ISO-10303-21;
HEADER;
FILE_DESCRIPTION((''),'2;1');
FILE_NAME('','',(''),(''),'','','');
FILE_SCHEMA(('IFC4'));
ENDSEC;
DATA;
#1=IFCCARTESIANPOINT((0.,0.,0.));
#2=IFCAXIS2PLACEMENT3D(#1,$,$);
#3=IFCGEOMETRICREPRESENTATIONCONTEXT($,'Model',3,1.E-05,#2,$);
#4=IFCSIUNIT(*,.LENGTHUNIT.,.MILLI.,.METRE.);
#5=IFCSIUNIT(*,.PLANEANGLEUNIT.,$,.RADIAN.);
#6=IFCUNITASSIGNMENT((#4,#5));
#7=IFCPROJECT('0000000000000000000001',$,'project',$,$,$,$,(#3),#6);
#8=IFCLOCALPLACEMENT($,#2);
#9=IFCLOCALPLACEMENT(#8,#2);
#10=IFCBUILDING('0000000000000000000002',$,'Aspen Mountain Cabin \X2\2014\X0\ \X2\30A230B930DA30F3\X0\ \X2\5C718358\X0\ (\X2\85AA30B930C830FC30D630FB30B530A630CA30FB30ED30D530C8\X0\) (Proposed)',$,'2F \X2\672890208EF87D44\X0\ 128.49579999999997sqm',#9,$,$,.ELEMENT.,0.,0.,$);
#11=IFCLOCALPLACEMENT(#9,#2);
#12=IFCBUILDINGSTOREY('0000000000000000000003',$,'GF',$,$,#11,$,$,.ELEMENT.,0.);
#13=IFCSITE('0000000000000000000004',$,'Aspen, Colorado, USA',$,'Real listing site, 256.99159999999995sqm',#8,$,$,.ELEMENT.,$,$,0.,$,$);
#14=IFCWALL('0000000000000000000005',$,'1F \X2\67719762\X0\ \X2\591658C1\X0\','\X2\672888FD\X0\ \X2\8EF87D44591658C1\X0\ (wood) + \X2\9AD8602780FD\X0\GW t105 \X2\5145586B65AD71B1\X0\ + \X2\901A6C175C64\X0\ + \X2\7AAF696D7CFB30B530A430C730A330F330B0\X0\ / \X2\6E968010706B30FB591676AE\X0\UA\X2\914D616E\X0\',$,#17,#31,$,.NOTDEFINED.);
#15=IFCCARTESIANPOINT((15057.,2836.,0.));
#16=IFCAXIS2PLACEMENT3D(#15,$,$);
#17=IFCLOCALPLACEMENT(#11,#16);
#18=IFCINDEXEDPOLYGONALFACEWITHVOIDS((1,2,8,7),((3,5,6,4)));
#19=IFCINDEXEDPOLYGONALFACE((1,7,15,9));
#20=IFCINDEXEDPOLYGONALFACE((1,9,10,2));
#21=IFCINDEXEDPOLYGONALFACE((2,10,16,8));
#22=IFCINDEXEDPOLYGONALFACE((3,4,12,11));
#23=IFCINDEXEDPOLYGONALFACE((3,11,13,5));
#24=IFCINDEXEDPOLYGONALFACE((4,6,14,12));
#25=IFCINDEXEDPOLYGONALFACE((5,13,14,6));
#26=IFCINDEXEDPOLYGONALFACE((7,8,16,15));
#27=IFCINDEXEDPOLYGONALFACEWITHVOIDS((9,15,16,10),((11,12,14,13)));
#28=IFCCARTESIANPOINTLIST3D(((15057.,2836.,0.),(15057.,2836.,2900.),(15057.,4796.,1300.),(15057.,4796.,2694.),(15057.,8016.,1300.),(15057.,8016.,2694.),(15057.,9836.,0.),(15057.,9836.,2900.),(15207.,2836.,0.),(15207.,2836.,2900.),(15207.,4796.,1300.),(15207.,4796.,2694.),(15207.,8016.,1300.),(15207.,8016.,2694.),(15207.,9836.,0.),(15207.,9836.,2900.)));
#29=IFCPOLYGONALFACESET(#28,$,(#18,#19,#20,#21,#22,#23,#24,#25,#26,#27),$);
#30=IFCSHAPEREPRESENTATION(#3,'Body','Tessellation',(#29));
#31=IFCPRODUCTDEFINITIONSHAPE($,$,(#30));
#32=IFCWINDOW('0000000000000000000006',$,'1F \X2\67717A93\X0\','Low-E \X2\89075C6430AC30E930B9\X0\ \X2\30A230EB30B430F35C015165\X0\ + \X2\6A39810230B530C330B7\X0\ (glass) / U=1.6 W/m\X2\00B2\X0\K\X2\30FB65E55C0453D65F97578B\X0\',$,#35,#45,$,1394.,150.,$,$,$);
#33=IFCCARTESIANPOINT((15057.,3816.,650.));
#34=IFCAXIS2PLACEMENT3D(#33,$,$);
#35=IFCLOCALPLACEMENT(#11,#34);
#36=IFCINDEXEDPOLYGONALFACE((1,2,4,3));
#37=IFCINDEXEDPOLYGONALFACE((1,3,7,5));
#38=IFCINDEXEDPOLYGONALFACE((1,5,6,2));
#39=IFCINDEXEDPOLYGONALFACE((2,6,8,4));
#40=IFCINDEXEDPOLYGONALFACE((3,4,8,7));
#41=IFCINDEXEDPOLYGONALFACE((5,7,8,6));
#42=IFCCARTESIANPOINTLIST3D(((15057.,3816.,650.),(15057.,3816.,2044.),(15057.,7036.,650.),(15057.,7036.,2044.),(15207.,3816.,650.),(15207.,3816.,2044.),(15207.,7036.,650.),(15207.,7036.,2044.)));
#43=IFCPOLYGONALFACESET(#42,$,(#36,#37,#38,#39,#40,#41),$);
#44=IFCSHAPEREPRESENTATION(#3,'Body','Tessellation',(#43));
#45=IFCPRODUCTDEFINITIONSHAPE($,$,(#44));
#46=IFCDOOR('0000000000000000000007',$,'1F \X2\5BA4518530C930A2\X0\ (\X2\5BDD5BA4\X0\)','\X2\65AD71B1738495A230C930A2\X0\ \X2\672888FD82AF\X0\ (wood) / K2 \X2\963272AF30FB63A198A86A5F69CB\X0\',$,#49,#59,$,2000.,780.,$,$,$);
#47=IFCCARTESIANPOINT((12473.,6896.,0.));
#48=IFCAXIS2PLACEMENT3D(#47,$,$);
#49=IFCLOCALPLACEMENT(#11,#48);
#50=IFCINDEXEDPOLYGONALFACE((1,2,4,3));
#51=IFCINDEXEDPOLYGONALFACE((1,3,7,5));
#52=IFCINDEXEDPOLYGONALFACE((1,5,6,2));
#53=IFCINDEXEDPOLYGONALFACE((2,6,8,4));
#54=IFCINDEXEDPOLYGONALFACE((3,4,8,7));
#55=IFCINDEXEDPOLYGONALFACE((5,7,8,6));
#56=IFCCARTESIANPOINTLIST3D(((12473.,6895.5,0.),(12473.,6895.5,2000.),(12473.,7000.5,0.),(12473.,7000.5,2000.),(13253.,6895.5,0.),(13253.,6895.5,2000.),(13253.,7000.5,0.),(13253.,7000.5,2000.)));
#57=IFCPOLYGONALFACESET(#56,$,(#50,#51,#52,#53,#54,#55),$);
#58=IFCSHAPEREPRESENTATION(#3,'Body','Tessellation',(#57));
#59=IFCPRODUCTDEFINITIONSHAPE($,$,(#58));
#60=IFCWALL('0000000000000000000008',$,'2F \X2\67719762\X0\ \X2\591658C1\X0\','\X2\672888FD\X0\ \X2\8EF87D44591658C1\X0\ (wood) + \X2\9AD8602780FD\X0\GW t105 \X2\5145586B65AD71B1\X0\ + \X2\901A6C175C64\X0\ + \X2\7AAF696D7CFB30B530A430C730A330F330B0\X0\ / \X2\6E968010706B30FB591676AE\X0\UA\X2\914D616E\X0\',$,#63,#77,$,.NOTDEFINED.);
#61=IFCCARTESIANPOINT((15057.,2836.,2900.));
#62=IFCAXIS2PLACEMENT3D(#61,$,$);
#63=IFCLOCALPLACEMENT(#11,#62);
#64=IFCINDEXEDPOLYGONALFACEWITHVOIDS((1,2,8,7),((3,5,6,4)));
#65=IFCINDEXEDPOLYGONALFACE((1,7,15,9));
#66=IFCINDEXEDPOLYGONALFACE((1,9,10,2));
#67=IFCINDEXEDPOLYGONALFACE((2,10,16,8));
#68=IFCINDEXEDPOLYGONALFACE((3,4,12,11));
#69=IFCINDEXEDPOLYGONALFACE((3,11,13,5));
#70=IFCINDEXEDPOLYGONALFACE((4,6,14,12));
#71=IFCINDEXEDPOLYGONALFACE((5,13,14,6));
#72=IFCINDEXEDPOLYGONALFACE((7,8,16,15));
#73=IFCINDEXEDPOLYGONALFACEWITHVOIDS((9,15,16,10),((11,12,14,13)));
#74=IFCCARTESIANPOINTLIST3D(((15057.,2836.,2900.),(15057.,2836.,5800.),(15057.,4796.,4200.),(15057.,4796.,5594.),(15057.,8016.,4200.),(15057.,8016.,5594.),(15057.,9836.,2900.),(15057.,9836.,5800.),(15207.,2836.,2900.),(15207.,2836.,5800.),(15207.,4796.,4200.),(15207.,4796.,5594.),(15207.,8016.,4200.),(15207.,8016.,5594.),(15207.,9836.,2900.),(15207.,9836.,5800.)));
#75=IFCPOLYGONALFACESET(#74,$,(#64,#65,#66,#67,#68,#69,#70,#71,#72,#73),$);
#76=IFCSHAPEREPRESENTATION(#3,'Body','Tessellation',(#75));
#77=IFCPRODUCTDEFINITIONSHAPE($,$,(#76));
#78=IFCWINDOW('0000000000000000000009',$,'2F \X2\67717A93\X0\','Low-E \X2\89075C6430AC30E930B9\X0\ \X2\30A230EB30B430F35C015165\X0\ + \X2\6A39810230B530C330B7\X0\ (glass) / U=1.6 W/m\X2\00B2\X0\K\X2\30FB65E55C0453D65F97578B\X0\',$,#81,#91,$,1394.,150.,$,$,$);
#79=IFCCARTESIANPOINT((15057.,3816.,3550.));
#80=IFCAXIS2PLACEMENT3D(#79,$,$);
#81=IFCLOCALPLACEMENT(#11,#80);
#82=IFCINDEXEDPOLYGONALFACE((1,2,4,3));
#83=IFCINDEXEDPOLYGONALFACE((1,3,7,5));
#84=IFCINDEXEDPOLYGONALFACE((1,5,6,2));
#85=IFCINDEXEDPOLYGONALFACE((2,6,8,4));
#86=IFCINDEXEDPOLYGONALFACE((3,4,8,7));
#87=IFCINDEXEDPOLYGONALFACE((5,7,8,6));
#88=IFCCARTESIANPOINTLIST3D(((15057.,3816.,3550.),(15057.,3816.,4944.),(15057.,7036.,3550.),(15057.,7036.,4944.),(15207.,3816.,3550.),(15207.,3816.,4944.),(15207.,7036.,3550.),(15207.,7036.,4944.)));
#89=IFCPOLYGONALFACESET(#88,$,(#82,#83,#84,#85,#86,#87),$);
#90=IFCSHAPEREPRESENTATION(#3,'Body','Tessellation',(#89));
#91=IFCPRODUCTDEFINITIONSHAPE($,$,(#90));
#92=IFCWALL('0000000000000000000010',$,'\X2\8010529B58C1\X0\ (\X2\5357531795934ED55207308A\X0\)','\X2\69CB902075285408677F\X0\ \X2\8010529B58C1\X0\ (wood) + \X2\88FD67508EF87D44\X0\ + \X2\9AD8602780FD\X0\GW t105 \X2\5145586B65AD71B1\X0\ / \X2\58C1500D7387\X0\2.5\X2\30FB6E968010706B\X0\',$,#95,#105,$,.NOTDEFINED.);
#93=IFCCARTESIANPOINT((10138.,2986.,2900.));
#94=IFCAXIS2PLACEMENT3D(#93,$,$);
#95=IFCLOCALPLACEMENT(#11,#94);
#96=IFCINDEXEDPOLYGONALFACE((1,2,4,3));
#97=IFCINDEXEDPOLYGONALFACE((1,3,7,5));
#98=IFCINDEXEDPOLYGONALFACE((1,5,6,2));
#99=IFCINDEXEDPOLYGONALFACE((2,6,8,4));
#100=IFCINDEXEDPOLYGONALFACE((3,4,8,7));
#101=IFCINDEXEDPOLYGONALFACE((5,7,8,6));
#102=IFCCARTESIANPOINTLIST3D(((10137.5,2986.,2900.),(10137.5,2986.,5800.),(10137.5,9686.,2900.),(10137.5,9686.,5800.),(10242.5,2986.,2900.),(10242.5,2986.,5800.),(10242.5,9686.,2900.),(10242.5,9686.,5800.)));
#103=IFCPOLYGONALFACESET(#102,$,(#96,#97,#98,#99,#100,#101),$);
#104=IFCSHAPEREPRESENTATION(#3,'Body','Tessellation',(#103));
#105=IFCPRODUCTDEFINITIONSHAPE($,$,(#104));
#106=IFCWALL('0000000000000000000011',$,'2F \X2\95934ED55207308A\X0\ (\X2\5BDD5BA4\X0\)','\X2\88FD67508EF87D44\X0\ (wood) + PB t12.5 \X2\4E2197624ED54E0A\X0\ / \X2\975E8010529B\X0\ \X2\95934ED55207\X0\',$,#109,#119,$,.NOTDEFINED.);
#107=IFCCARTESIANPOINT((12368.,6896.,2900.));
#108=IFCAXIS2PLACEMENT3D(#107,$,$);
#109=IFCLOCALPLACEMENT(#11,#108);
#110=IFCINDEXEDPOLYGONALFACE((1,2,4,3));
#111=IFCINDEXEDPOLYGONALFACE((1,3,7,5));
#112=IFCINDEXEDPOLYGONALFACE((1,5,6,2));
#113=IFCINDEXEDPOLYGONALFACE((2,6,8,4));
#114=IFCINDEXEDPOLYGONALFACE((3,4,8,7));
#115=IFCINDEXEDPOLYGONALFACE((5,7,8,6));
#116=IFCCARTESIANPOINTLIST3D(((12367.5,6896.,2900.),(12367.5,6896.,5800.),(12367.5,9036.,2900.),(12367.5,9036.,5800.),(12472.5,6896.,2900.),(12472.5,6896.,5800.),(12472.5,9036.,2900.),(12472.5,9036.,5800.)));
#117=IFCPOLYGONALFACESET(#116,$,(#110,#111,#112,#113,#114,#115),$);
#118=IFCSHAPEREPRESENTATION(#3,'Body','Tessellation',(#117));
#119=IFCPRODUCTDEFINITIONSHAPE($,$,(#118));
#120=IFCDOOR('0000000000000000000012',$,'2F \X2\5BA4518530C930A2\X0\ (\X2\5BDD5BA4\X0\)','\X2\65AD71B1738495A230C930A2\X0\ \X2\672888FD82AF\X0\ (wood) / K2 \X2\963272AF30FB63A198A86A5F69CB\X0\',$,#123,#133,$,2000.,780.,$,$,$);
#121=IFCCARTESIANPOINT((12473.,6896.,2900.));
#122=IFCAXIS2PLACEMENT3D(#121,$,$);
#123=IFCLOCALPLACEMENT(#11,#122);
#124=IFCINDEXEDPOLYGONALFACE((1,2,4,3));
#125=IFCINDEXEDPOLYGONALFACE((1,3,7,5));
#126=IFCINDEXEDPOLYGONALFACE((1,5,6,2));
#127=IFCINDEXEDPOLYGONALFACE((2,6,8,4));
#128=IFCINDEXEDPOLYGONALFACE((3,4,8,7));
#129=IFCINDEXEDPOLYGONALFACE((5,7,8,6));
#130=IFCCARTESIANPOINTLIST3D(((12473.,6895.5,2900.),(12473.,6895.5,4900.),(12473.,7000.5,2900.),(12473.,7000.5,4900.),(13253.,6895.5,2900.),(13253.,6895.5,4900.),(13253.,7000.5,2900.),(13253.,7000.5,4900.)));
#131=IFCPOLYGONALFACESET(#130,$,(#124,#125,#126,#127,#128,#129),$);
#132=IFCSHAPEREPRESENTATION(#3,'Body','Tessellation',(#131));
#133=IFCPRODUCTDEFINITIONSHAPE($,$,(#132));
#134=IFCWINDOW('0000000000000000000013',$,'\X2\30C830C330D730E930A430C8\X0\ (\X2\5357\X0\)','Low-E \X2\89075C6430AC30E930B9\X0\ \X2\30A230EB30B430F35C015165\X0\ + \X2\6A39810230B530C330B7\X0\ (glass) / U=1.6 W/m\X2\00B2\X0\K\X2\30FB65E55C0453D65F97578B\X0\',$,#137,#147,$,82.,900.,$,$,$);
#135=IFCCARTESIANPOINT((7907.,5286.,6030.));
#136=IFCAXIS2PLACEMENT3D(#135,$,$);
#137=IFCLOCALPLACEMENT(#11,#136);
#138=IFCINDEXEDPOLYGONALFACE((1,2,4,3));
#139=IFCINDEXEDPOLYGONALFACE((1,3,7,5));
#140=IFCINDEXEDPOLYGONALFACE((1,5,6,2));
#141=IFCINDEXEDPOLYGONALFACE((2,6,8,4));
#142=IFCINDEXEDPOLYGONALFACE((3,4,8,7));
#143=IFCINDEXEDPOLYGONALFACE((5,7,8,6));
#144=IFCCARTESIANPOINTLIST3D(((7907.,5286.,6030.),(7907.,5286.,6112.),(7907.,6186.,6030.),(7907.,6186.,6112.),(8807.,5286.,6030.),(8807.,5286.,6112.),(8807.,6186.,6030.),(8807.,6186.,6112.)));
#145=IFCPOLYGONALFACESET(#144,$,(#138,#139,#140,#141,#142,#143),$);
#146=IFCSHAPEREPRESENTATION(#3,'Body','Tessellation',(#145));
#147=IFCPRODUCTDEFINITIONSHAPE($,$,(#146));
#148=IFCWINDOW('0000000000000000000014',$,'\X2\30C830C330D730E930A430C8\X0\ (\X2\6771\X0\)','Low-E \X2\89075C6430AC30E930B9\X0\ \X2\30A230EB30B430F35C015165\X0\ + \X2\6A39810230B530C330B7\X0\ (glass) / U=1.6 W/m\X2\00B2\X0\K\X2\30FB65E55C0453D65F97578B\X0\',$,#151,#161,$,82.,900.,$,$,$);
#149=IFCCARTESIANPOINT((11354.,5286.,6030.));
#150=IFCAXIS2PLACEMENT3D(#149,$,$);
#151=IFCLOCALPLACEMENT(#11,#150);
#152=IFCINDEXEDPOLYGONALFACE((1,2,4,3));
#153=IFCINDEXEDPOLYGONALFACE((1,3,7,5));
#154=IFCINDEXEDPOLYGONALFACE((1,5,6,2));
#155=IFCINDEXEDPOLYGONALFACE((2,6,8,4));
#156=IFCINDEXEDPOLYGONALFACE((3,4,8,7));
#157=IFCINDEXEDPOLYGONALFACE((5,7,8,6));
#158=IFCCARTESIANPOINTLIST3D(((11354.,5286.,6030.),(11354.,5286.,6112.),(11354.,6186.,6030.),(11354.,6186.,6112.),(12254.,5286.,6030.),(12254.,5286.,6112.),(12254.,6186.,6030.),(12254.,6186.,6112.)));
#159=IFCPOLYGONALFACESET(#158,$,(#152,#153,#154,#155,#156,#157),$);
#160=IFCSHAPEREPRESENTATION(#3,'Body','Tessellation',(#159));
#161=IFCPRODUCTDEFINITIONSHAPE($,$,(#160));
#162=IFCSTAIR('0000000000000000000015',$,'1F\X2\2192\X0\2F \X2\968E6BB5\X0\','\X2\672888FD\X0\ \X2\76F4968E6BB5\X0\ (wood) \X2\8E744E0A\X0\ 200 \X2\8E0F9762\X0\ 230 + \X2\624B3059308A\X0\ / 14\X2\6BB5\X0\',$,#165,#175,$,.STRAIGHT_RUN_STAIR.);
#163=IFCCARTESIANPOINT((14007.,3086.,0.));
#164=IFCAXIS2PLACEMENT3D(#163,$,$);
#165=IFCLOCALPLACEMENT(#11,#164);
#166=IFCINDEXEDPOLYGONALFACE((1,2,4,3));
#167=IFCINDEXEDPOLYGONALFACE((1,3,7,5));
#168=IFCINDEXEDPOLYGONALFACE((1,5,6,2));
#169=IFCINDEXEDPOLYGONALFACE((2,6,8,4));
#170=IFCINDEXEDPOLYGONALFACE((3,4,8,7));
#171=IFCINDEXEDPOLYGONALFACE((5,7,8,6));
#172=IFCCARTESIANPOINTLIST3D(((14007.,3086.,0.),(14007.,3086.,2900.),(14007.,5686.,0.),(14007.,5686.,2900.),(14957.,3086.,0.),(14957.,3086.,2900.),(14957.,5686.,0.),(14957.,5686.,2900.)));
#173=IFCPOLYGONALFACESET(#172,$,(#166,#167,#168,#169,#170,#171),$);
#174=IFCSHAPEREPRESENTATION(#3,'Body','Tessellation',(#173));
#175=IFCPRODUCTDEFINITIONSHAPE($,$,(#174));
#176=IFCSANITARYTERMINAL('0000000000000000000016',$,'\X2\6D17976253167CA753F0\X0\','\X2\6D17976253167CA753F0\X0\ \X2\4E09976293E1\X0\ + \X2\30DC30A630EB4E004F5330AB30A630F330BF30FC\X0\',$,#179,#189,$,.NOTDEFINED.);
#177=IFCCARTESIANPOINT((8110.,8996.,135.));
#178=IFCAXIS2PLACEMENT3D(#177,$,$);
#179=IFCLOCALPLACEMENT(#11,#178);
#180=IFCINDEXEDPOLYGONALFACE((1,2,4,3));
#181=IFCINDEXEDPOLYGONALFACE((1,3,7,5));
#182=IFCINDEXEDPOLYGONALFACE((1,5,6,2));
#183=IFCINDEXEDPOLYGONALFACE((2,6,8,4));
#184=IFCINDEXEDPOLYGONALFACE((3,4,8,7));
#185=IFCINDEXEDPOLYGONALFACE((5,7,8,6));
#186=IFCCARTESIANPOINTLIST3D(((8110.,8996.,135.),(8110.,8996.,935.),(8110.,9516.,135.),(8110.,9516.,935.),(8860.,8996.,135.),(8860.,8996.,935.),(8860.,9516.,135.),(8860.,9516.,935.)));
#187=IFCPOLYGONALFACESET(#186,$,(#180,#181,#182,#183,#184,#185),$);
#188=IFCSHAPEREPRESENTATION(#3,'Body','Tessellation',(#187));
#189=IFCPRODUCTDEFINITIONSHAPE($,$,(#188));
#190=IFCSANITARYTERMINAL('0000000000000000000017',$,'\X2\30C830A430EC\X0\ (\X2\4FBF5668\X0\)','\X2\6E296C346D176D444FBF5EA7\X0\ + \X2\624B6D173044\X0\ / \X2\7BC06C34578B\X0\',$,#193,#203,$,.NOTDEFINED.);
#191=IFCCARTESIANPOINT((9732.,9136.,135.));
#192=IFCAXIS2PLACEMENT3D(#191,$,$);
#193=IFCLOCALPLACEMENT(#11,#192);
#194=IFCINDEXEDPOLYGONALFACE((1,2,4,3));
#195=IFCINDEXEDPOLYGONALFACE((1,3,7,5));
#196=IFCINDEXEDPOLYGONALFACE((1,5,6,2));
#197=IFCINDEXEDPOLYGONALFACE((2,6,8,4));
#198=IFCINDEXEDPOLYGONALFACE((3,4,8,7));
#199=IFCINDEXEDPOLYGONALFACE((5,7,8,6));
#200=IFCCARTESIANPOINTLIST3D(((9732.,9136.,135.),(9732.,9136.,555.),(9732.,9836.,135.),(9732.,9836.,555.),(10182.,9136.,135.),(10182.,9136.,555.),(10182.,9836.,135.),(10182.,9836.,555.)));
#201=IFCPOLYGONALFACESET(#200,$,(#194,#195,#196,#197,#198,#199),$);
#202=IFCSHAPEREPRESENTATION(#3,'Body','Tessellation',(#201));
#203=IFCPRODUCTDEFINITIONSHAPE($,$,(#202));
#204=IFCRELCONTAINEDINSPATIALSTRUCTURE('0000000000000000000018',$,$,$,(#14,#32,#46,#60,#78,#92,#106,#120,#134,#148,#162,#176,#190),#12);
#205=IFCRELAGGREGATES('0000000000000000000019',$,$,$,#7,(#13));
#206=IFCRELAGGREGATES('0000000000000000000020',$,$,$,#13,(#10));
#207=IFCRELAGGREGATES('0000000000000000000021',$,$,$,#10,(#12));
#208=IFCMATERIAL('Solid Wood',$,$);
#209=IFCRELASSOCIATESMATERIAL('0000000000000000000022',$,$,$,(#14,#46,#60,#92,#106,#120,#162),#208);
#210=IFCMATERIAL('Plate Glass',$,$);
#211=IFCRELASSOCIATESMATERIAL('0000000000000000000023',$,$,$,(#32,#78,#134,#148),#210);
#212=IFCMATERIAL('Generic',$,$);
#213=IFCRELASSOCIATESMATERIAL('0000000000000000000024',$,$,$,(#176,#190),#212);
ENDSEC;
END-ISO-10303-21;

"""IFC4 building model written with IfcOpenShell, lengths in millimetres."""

from ifc_helpers import new_model, si_unit, frame, frame_2d, origin, place, context, project, spatial, rectangle, extrude, material, element, fill, save


model = new_model("IFC4")

# Units and contexts
model_context = context("Model", 3, precision=1e-05, world=origin())
ifc_project = project(units=[si_unit("LENGTHUNIT", "METRE", prefix="MILLI"), si_unit("PLANEANGLEUNIT", "RADIAN")], contexts=[model_context])

# Site, building, storey
site_placement = place(None, origin())
site = spatial("IfcSite", under=ifc_project, at=site_placement, Name="Aspen, Colorado, USA", ObjectType="Real listing site, 256.99159999999995sqm", CompositionType="ELEMENT", RefElevation=0.0)
building_placement = place(site_placement, origin())
building = spatial("IfcBuilding", under=site, at=building_placement, Name="Aspen Mountain Cabin — アスペン 山荘 (薪ストーブ・サウナ・ロフト) (Proposed)", ObjectType="2F 木造軸組 128.49579999999997sqm", CompositionType="ELEMENT", ElevationOfRefHeight=0.0, ElevationOfTerrain=0.0)
storey_placement = place(building_placement, origin())
storey = spatial("IfcBuildingStorey", under=building, at=storey_placement, Name="GF", CompositionType="ELEMENT", Elevation=0.0)

# Wall, opening, window
ifc_material_1 = material(Name="Solid Wood")
wall_1_placement = place(storey_placement, frame((15057.0, 2836.0, 0.0)))
wall_1 = element("IfcWall", 1, at=wall_1_placement, inside=storey, material=ifc_material_1, Name="1F 東面 外壁", Description="木製 軸組外壁 (wood) + 高性能GW t105 充填断熱 + 通気層 + 窯業系サイディング / 準耐火・外皮UA配慮", PredefinedType="NOTDEFINED", context=model_context, shape_type="SweptSolid", body=[
    extrude(rectangle(XDim=150.0, YDim=7000.0, at=frame_2d((75.0, 3500.0))), frame((15057.0, 2836.0, 0.0)), (0.0, 0.0, 1.0), 2900.0),
])
opening_1_placement = place(storey_placement, frame((15057.0, 3816.0, 650.0)))
opening_1 = element("IfcOpeningElement", 2, at=opening_1_placement, cuts=wall_1, PredefinedType="NOTDEFINED", context=model_context, shape_type="SweptSolid", body=[
    extrude(rectangle(XDim=150.0, YDim=3220.0, at=frame_2d((75.0, 1610.0))), frame((15057.0, 3816.0, 650.0)), (0.0, 0.0, 1.0), 1394.0),
])
ifc_material_2 = material(Name="Plate Glass")
window_1_placement = place(storey_placement, frame((15057.0, 3816.0, 650.0)))
window_1 = element("IfcWindow", 3, at=window_1_placement, inside=storey, material=ifc_material_2, Name="1F 東窓", Description="Low-E 複層ガラス アルゴン封入 + 樹脂サッシ (glass) / U=1.6 W/m²K・日射取得型", OverallHeight=1394.0, OverallWidth=150.0, context=model_context, shape_type="SweptSolid", body=[
    extrude(rectangle(XDim=150.0, YDim=3220.0, at=frame_2d((75.0, 1610.0))), frame((15057.0, 3816.0, 650.0)), (0.0, 0.0, 1.0), 1394.0),
])
fill(opening_1, window_1)

# Door
door_1_placement = place(storey_placement, frame((12473.0, 6896.0, 0.0)))
element("IfcDoor", 4, at=door_1_placement, inside=storey, material=ifc_material_1, Name="1F 室内ドア (寝室)", Description="断熱玄関ドア 木製芯 (wood) / K2 防犯・採風機構", OverallHeight=2000.0, OverallWidth=780.0, context=model_context, shape_type="SweptSolid", body=[
    extrude(rectangle(XDim=780.0, YDim=105.0, at=frame_2d((390.0, 52.0))), frame((12473.0, 6896.0, 0.0)), (0.0, 0.0, 1.0), 2000.0),
])

# Wall, opening, window
wall_2_placement = place(storey_placement, frame((15057.0, 2836.0, 2900.0)))
wall_2 = element("IfcWall", 5, at=wall_2_placement, inside=storey, material=ifc_material_1, Name="2F 東面 外壁", Description="木製 軸組外壁 (wood) + 高性能GW t105 充填断熱 + 通気層 + 窯業系サイディング / 準耐火・外皮UA配慮", PredefinedType="NOTDEFINED", context=model_context, shape_type="SweptSolid", body=[
    extrude(rectangle(XDim=150.0, YDim=7000.0, at=frame_2d((75.0, 3500.0))), frame((15057.0, 2836.0, 2900.0)), (0.0, 0.0, 1.0), 2900.0),
])
opening_2_placement = place(storey_placement, frame((15057.0, 3816.0, 3550.0)))
opening_2 = element("IfcOpeningElement", 6, at=opening_2_placement, cuts=wall_2, PredefinedType="NOTDEFINED", context=model_context, shape_type="SweptSolid", body=[
    extrude(rectangle(XDim=150.0, YDim=3220.0, at=frame_2d((75.0, 1610.0))), frame((15057.0, 3816.0, 3550.0)), (0.0, 0.0, 1.0), 1394.0),
])
window_2_placement = place(storey_placement, frame((15057.0, 3816.0, 3550.0)))
window_2 = element("IfcWindow", 7, at=window_2_placement, inside=storey, material=ifc_material_2, Name="2F 東窓", Description="Low-E 複層ガラス アルゴン封入 + 樹脂サッシ (glass) / U=1.6 W/m²K・日射取得型", OverallHeight=1394.0, OverallWidth=150.0, context=model_context, shape_type="SweptSolid", body=[
    extrude(rectangle(XDim=150.0, YDim=3220.0, at=frame_2d((75.0, 1610.0))), frame((15057.0, 3816.0, 3550.0)), (0.0, 0.0, 1.0), 1394.0),
])
fill(opening_2, window_2)

# Walls
wall_3_placement = place(storey_placement, frame((10138.0, 2986.0, 2900.0)))
element("IfcWall", 8, at=wall_3_placement, inside=storey, material=ifc_material_1, Name="耐力壁 (南北間仕切り)", Description="構造用合板 耐力壁 (wood) + 製材軸組 + 高性能GW t105 充填断熱 / 壁倍率2.5・準耐火", PredefinedType="NOTDEFINED", context=model_context, shape_type="SweptSolid", body=[
    extrude(rectangle(XDim=105.0, YDim=6700.0, at=frame_2d((52.0, 3350.0))), frame((10138.0, 2986.0, 2900.0)), (0.0, 0.0, 1.0), 2900.0),
])
wall_4_placement = place(storey_placement, frame((12368.0, 6896.0, 2900.0)))
element("IfcWall", 9, at=wall_4_placement, inside=storey, material=ifc_material_1, Name="2F 間仕切り (寝室)", Description="製材軸組 (wood) + PB t12.5 両面仕上 / 非耐力 間仕切", PredefinedType="NOTDEFINED", context=model_context, shape_type="SweptSolid", body=[
    extrude(rectangle(XDim=105.0, YDim=2140.0, at=frame_2d((52.0, 1070.0))), frame((12368.0, 6896.0, 2900.0)), (0.0, 0.0, 1.0), 2900.0),
])

# Door
door_2_placement = place(storey_placement, frame((12473.0, 6896.0, 2900.0)))
element("IfcDoor", 10, at=door_2_placement, inside=storey, material=ifc_material_1, Name="2F 室内ドア (寝室)", Description="断熱玄関ドア 木製芯 (wood) / K2 防犯・採風機構", OverallHeight=2000.0, OverallWidth=780.0, context=model_context, shape_type="SweptSolid", body=[
    extrude(rectangle(XDim=780.0, YDim=105.0, at=frame_2d((390.0, 52.0))), frame((12473.0, 6896.0, 2900.0)), (0.0, 0.0, 1.0), 2000.0),
])

# Windows
window_3_placement = place(storey_placement, frame((7907.0, 5286.0, 6030.0)))
element("IfcWindow", 11, at=window_3_placement, inside=storey, material=ifc_material_2, Name="トップライト (南)", Description="Low-E 複層ガラス アルゴン封入 + 樹脂サッシ (glass) / U=1.6 W/m²K・日射取得型", OverallHeight=82.0, OverallWidth=900.0, context=model_context, shape_type="SweptSolid", body=[
    extrude(rectangle(XDim=900.0, YDim=900.0, at=frame_2d((450.0, 450.0))), frame((7907.0, 5286.0, 6030.0)), (0.0, 0.0, 1.0), 82.0),
])
window_4_placement = place(storey_placement, frame((11354.0, 5286.0, 6030.0)))
element("IfcWindow", 12, at=window_4_placement, inside=storey, material=ifc_material_2, Name="トップライト (東)", Description="Low-E 複層ガラス アルゴン封入 + 樹脂サッシ (glass) / U=1.6 W/m²K・日射取得型", OverallHeight=82.0, OverallWidth=900.0, context=model_context, shape_type="SweptSolid", body=[
    extrude(rectangle(XDim=900.0, YDim=900.0, at=frame_2d((450.0, 450.0))), frame((11354.0, 5286.0, 6030.0)), (0.0, 0.0, 1.0), 82.0),
])

# Stair
stair_placement = place(storey_placement, frame((14007.0, 3086.0, 0.0)))
element("IfcStair", 13, at=stair_placement, inside=storey, material=ifc_material_1, Name="1F→2F 階段", Description="木製 直階段 (wood) 蹴上 200 踏面 230 + 手すり / 14段", PredefinedType="STRAIGHT_RUN_STAIR", context=model_context, shape_type="SweptSolid", body=[
    extrude(rectangle(XDim=950.0, YDim=2600.0, at=frame_2d((475.0, 1300.0))), frame((14007.0, 3086.0, 0.0)), (0.0, 0.0, 1.0), 2900.0),
])

# Sanitary terminals
ifc_material_3 = material(Name="Generic")
sanitary_terminal_1_placement = place(storey_placement, frame((8110.0, 8996.0, 135.0)))
element("IfcSanitaryTerminal", 14, at=sanitary_terminal_1_placement, inside=storey, material=ifc_material_3, Name="洗面化粧台", Description="洗面化粧台 三面鏡 + ボウル一体カウンター", PredefinedType="NOTDEFINED", context=model_context, shape_type="SweptSolid", body=[
    extrude(rectangle(XDim=750.0, YDim=520.0, at=frame_2d((375.0, 260.0))), frame((8110.0, 8996.0, 135.0)), (0.0, 0.0, 1.0), 800.0),
])
sanitary_terminal_2_placement = place(storey_placement, frame((9732.0, 9136.0, 135.0)))
element("IfcSanitaryTerminal", 15, at=sanitary_terminal_2_placement, inside=storey, material=ifc_material_3, Name="トイレ (便器)", Description="温水洗浄便座 + 手洗い / 節水型", PredefinedType="NOTDEFINED", context=model_context, shape_type="SweptSolid", body=[
    extrude(rectangle(XDim=450.0, YDim=700.0, at=frame_2d((225.0, 350.0))), frame((9732.0, 9136.0, 135.0)), (0.0, 0.0, 1.0), 420.0),
])

save(model, "model.ifc")
